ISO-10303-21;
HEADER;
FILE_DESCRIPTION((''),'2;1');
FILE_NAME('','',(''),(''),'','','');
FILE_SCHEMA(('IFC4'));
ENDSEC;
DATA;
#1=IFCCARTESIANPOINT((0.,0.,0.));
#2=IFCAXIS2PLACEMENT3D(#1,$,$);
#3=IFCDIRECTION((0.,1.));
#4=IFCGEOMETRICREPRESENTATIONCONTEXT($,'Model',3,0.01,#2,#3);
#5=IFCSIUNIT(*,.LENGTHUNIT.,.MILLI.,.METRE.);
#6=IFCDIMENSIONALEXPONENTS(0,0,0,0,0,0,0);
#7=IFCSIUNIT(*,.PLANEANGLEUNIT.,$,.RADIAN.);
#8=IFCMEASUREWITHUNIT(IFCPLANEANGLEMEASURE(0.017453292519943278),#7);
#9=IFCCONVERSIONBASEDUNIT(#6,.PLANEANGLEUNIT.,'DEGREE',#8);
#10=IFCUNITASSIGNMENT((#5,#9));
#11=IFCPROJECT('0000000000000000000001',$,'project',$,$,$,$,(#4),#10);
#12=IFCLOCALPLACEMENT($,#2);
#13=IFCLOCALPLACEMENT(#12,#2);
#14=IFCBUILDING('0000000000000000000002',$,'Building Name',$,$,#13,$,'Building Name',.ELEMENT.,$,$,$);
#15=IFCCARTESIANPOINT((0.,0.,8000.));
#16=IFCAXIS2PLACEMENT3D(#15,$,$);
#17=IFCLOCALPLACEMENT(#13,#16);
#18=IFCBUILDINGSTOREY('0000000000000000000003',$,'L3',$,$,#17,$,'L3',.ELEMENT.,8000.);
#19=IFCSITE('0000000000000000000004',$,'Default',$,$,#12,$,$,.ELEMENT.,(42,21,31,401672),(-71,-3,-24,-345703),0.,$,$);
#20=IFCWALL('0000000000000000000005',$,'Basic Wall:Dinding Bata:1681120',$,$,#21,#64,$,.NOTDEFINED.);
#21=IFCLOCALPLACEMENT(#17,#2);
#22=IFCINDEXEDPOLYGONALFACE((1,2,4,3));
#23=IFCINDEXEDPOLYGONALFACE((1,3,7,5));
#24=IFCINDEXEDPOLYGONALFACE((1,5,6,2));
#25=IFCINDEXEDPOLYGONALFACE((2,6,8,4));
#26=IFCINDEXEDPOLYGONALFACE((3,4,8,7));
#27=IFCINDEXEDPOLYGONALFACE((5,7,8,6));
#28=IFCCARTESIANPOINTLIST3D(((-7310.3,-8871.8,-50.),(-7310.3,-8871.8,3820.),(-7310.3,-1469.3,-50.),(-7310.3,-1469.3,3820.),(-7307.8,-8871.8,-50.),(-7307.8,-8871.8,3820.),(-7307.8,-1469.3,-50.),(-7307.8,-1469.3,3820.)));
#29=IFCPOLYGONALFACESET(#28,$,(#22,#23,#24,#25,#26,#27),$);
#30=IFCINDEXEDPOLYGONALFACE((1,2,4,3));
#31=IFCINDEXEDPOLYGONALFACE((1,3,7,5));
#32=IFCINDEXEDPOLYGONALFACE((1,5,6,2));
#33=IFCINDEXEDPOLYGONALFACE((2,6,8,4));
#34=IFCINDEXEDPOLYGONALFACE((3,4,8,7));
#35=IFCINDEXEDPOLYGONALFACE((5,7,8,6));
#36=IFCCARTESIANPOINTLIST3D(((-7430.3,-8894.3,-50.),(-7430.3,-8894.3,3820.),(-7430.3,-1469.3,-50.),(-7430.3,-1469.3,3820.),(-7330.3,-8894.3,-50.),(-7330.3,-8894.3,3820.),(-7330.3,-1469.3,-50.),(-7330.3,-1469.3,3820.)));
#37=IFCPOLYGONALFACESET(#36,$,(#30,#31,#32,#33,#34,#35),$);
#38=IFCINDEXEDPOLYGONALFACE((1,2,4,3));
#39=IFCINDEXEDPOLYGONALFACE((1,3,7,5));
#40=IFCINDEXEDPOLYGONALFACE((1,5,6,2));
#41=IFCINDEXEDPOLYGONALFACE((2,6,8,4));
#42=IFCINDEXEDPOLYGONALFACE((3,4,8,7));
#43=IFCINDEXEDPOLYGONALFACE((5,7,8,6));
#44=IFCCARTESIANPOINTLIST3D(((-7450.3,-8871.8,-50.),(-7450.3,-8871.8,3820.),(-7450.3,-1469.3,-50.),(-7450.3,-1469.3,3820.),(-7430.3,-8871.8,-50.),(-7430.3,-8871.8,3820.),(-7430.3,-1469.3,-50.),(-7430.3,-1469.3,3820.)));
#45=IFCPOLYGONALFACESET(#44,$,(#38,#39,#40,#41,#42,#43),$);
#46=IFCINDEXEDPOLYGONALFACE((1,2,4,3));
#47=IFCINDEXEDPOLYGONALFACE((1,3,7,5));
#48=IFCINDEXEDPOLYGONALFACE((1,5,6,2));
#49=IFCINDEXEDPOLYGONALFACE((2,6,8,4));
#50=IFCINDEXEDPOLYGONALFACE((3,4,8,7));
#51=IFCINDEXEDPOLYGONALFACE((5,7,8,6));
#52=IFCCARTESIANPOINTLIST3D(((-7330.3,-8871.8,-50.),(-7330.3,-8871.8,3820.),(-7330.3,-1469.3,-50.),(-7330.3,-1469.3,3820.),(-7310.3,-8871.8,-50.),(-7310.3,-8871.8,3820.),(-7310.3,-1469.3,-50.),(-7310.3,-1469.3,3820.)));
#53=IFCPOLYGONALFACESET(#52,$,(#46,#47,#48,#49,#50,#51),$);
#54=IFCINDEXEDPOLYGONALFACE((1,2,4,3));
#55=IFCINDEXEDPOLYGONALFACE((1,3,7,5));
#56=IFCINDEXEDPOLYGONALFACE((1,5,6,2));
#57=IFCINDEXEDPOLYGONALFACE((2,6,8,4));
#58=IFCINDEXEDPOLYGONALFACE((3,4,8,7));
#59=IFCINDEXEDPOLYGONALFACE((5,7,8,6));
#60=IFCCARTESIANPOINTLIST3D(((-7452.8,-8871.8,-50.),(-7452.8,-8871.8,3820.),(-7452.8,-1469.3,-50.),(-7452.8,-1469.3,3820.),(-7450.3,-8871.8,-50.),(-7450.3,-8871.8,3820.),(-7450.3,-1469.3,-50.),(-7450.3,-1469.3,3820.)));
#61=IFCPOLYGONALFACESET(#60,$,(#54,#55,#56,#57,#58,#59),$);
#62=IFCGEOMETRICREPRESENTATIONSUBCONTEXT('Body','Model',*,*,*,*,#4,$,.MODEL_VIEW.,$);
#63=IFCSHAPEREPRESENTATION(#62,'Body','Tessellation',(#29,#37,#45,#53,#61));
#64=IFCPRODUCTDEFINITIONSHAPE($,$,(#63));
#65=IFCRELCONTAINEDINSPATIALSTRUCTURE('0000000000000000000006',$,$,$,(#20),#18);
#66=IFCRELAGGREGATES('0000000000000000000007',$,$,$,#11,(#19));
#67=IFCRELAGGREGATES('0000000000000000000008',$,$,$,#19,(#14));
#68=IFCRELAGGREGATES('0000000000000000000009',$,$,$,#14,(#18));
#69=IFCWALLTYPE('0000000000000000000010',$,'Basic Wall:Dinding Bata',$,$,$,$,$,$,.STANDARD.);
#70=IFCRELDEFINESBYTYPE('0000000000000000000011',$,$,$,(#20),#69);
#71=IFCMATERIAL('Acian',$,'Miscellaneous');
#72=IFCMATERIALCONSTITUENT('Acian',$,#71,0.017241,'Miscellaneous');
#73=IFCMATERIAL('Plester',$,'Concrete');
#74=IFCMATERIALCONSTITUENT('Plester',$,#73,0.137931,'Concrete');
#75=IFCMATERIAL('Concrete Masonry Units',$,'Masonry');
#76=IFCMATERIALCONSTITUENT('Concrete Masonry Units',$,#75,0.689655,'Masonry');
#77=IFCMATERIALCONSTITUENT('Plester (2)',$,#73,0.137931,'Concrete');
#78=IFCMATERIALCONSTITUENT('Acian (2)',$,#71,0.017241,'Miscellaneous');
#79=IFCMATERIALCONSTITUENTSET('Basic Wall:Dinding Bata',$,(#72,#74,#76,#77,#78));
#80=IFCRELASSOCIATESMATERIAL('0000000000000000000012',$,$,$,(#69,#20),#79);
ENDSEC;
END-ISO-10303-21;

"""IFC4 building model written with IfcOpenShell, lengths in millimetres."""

from ifc_helpers import new_model, entity, si_unit, converted_unit, direction, frame, origin, place, context, subcontext, project, spatial, indexed_curve, outline, extrude, material, constituent, constituent_set, type_object, element, save


model = new_model("IFC4")

# Units and contexts
model_context = context("Model", 3, precision=0.01, world=origin(), true_north=direction((0.0, 1.0)))
body_context = subcontext(model_context, "Body", "Model", "MODEL_VIEW")
ifc_project = project(units=[si_unit("LENGTHUNIT", "METRE", prefix="MILLI"), converted_unit("PLANEANGLEUNIT", "DEGREE", entity("IfcPlaneAngleMeasure", 0.017453292519943278), si_unit("PLANEANGLEUNIT", "RADIAN"), dimensions=[0, 0, 0, 0, 0, 0, 0])], contexts=[model_context])

# Site, building, storey
site_placement = place(None, origin())
site = spatial("IfcSite", under=ifc_project, at=site_placement, Name="Default", CompositionType="ELEMENT", RefLatitude=(42, 21, 31, 401672), RefLongitude=(-71, -3, -24, -345703), RefElevation=0.0)
building_placement = place(site_placement, origin())
building = spatial("IfcBuilding", under=site, at=building_placement, Name="Building Name", LongName="Building Name", CompositionType="ELEMENT")
storey_placement = place(building_placement, frame((0.0, 0.0, 8000.0)))
storey = spatial("IfcBuildingStorey", under=building, at=storey_placement, Name="L3", LongName="L3", CompositionType="ELEMENT", Elevation=8000.0)

# Wall
ifc_material_1 = material(Name="Acian", Category="Miscellaneous")
ifc_constituent_1 = constituent(ifc_material_1, Name="Acian", Category="Miscellaneous", fraction=0.017241)
ifc_material_2 = material(Name="Plester", Category="Concrete")
ifc_constituent_2 = constituent(ifc_material_2, Name="Plester", Category="Concrete", fraction=0.137931)
ifc_material_3 = material(Name="Concrete Masonry Units", Category="Masonry")
ifc_constituent_3 = constituent(ifc_material_3, Name="Concrete Masonry Units", Category="Masonry", fraction=0.689655)
ifc_constituent_4 = constituent(ifc_material_2, Name="Plester (2)", Category="Concrete", fraction=0.137931)
ifc_constituent_5 = constituent(ifc_material_1, Name="Acian (2)", Category="Miscellaneous", fraction=0.017241)
ifc_constituent_set = constituent_set(constituents=[ifc_constituent_1, ifc_constituent_2, ifc_constituent_3, ifc_constituent_4, ifc_constituent_5], Name="Basic Wall:Dinding Bata")
wall_type = type_object("IfcWallType", Name="Basic Wall:Dinding Bata", PredefinedType="STANDARD", material=ifc_constituent_set)
wall_1_placement = place(storey_placement, frame((-7380.3, -1469.3, -50.0), z_axis=(0.0, 0.0, 1.0), x_axis=(0.0, -1.0, 0.0)))
element("IfcWall", 1, at=wall_1_placement, inside=storey, type_object=wall_type, material=ifc_constituent_set, Name="Basic Wall:Dinding Bata:1681120", PredefinedType="NOTDEFINED", context=body_context, shape_type="SweptSolid", body=[
    extrude(outline(indexed_curve([(-1.3, -3701.3), (1.2, -3701.3), (1.3, 3701.3), (-1.2, 3701.3), (-1.3, -3701.3)], self_intersect=False)), frame((3701.3, 71.3, 0.0), z_axis=(0.0, 0.0, 1.0), x_axis=(0.0, -1.0, 0.0)), (0.0, 0.0, 1.0), 3870.0),
    extrude(outline(indexed_curve([(-3712.5, -50.0), (3712.5, -50.0), (3712.5, 50.0), (-3712.5, 50.0), (-3712.5, -50.0)], self_intersect=False)), frame((3712.5, 0.0, 0.0)), (0.0, 0.0, 1.0), 3870.0),
    extrude(outline(indexed_curve([(-3701.3, -10.0), (3701.3, -10.0), (3701.3, 10.0), (-3701.3, 10.0), (-3701.3, -10.0)], self_intersect=False)), frame((3701.3, -60.0, 0.0)), (0.0, 0.0, 1.0), 3870.0),
    extrude(outline(indexed_curve([(-3701.3, -10.0), (3701.3, -10.0), (3701.3, 10.0), (-3701.3, 10.0), (-3701.3, -10.0)], self_intersect=False)), frame((3701.3, 60.0, 0.0)), (0.0, 0.0, 1.0), 3870.0),
    extrude(outline(indexed_curve([(-1.3, -3701.3), (1.2, -3701.3), (1.3, 3701.3), (-1.2, 3701.3), (-1.3, -3701.3)], self_intersect=False)), frame((3701.3, -71.3, 0.0), z_axis=(0.0, 0.0, 1.0), x_axis=(0.0, 1.0, 0.0)), (0.0, 0.0, 1.0), 3870.0),
])

save(model, "model.ifc")
